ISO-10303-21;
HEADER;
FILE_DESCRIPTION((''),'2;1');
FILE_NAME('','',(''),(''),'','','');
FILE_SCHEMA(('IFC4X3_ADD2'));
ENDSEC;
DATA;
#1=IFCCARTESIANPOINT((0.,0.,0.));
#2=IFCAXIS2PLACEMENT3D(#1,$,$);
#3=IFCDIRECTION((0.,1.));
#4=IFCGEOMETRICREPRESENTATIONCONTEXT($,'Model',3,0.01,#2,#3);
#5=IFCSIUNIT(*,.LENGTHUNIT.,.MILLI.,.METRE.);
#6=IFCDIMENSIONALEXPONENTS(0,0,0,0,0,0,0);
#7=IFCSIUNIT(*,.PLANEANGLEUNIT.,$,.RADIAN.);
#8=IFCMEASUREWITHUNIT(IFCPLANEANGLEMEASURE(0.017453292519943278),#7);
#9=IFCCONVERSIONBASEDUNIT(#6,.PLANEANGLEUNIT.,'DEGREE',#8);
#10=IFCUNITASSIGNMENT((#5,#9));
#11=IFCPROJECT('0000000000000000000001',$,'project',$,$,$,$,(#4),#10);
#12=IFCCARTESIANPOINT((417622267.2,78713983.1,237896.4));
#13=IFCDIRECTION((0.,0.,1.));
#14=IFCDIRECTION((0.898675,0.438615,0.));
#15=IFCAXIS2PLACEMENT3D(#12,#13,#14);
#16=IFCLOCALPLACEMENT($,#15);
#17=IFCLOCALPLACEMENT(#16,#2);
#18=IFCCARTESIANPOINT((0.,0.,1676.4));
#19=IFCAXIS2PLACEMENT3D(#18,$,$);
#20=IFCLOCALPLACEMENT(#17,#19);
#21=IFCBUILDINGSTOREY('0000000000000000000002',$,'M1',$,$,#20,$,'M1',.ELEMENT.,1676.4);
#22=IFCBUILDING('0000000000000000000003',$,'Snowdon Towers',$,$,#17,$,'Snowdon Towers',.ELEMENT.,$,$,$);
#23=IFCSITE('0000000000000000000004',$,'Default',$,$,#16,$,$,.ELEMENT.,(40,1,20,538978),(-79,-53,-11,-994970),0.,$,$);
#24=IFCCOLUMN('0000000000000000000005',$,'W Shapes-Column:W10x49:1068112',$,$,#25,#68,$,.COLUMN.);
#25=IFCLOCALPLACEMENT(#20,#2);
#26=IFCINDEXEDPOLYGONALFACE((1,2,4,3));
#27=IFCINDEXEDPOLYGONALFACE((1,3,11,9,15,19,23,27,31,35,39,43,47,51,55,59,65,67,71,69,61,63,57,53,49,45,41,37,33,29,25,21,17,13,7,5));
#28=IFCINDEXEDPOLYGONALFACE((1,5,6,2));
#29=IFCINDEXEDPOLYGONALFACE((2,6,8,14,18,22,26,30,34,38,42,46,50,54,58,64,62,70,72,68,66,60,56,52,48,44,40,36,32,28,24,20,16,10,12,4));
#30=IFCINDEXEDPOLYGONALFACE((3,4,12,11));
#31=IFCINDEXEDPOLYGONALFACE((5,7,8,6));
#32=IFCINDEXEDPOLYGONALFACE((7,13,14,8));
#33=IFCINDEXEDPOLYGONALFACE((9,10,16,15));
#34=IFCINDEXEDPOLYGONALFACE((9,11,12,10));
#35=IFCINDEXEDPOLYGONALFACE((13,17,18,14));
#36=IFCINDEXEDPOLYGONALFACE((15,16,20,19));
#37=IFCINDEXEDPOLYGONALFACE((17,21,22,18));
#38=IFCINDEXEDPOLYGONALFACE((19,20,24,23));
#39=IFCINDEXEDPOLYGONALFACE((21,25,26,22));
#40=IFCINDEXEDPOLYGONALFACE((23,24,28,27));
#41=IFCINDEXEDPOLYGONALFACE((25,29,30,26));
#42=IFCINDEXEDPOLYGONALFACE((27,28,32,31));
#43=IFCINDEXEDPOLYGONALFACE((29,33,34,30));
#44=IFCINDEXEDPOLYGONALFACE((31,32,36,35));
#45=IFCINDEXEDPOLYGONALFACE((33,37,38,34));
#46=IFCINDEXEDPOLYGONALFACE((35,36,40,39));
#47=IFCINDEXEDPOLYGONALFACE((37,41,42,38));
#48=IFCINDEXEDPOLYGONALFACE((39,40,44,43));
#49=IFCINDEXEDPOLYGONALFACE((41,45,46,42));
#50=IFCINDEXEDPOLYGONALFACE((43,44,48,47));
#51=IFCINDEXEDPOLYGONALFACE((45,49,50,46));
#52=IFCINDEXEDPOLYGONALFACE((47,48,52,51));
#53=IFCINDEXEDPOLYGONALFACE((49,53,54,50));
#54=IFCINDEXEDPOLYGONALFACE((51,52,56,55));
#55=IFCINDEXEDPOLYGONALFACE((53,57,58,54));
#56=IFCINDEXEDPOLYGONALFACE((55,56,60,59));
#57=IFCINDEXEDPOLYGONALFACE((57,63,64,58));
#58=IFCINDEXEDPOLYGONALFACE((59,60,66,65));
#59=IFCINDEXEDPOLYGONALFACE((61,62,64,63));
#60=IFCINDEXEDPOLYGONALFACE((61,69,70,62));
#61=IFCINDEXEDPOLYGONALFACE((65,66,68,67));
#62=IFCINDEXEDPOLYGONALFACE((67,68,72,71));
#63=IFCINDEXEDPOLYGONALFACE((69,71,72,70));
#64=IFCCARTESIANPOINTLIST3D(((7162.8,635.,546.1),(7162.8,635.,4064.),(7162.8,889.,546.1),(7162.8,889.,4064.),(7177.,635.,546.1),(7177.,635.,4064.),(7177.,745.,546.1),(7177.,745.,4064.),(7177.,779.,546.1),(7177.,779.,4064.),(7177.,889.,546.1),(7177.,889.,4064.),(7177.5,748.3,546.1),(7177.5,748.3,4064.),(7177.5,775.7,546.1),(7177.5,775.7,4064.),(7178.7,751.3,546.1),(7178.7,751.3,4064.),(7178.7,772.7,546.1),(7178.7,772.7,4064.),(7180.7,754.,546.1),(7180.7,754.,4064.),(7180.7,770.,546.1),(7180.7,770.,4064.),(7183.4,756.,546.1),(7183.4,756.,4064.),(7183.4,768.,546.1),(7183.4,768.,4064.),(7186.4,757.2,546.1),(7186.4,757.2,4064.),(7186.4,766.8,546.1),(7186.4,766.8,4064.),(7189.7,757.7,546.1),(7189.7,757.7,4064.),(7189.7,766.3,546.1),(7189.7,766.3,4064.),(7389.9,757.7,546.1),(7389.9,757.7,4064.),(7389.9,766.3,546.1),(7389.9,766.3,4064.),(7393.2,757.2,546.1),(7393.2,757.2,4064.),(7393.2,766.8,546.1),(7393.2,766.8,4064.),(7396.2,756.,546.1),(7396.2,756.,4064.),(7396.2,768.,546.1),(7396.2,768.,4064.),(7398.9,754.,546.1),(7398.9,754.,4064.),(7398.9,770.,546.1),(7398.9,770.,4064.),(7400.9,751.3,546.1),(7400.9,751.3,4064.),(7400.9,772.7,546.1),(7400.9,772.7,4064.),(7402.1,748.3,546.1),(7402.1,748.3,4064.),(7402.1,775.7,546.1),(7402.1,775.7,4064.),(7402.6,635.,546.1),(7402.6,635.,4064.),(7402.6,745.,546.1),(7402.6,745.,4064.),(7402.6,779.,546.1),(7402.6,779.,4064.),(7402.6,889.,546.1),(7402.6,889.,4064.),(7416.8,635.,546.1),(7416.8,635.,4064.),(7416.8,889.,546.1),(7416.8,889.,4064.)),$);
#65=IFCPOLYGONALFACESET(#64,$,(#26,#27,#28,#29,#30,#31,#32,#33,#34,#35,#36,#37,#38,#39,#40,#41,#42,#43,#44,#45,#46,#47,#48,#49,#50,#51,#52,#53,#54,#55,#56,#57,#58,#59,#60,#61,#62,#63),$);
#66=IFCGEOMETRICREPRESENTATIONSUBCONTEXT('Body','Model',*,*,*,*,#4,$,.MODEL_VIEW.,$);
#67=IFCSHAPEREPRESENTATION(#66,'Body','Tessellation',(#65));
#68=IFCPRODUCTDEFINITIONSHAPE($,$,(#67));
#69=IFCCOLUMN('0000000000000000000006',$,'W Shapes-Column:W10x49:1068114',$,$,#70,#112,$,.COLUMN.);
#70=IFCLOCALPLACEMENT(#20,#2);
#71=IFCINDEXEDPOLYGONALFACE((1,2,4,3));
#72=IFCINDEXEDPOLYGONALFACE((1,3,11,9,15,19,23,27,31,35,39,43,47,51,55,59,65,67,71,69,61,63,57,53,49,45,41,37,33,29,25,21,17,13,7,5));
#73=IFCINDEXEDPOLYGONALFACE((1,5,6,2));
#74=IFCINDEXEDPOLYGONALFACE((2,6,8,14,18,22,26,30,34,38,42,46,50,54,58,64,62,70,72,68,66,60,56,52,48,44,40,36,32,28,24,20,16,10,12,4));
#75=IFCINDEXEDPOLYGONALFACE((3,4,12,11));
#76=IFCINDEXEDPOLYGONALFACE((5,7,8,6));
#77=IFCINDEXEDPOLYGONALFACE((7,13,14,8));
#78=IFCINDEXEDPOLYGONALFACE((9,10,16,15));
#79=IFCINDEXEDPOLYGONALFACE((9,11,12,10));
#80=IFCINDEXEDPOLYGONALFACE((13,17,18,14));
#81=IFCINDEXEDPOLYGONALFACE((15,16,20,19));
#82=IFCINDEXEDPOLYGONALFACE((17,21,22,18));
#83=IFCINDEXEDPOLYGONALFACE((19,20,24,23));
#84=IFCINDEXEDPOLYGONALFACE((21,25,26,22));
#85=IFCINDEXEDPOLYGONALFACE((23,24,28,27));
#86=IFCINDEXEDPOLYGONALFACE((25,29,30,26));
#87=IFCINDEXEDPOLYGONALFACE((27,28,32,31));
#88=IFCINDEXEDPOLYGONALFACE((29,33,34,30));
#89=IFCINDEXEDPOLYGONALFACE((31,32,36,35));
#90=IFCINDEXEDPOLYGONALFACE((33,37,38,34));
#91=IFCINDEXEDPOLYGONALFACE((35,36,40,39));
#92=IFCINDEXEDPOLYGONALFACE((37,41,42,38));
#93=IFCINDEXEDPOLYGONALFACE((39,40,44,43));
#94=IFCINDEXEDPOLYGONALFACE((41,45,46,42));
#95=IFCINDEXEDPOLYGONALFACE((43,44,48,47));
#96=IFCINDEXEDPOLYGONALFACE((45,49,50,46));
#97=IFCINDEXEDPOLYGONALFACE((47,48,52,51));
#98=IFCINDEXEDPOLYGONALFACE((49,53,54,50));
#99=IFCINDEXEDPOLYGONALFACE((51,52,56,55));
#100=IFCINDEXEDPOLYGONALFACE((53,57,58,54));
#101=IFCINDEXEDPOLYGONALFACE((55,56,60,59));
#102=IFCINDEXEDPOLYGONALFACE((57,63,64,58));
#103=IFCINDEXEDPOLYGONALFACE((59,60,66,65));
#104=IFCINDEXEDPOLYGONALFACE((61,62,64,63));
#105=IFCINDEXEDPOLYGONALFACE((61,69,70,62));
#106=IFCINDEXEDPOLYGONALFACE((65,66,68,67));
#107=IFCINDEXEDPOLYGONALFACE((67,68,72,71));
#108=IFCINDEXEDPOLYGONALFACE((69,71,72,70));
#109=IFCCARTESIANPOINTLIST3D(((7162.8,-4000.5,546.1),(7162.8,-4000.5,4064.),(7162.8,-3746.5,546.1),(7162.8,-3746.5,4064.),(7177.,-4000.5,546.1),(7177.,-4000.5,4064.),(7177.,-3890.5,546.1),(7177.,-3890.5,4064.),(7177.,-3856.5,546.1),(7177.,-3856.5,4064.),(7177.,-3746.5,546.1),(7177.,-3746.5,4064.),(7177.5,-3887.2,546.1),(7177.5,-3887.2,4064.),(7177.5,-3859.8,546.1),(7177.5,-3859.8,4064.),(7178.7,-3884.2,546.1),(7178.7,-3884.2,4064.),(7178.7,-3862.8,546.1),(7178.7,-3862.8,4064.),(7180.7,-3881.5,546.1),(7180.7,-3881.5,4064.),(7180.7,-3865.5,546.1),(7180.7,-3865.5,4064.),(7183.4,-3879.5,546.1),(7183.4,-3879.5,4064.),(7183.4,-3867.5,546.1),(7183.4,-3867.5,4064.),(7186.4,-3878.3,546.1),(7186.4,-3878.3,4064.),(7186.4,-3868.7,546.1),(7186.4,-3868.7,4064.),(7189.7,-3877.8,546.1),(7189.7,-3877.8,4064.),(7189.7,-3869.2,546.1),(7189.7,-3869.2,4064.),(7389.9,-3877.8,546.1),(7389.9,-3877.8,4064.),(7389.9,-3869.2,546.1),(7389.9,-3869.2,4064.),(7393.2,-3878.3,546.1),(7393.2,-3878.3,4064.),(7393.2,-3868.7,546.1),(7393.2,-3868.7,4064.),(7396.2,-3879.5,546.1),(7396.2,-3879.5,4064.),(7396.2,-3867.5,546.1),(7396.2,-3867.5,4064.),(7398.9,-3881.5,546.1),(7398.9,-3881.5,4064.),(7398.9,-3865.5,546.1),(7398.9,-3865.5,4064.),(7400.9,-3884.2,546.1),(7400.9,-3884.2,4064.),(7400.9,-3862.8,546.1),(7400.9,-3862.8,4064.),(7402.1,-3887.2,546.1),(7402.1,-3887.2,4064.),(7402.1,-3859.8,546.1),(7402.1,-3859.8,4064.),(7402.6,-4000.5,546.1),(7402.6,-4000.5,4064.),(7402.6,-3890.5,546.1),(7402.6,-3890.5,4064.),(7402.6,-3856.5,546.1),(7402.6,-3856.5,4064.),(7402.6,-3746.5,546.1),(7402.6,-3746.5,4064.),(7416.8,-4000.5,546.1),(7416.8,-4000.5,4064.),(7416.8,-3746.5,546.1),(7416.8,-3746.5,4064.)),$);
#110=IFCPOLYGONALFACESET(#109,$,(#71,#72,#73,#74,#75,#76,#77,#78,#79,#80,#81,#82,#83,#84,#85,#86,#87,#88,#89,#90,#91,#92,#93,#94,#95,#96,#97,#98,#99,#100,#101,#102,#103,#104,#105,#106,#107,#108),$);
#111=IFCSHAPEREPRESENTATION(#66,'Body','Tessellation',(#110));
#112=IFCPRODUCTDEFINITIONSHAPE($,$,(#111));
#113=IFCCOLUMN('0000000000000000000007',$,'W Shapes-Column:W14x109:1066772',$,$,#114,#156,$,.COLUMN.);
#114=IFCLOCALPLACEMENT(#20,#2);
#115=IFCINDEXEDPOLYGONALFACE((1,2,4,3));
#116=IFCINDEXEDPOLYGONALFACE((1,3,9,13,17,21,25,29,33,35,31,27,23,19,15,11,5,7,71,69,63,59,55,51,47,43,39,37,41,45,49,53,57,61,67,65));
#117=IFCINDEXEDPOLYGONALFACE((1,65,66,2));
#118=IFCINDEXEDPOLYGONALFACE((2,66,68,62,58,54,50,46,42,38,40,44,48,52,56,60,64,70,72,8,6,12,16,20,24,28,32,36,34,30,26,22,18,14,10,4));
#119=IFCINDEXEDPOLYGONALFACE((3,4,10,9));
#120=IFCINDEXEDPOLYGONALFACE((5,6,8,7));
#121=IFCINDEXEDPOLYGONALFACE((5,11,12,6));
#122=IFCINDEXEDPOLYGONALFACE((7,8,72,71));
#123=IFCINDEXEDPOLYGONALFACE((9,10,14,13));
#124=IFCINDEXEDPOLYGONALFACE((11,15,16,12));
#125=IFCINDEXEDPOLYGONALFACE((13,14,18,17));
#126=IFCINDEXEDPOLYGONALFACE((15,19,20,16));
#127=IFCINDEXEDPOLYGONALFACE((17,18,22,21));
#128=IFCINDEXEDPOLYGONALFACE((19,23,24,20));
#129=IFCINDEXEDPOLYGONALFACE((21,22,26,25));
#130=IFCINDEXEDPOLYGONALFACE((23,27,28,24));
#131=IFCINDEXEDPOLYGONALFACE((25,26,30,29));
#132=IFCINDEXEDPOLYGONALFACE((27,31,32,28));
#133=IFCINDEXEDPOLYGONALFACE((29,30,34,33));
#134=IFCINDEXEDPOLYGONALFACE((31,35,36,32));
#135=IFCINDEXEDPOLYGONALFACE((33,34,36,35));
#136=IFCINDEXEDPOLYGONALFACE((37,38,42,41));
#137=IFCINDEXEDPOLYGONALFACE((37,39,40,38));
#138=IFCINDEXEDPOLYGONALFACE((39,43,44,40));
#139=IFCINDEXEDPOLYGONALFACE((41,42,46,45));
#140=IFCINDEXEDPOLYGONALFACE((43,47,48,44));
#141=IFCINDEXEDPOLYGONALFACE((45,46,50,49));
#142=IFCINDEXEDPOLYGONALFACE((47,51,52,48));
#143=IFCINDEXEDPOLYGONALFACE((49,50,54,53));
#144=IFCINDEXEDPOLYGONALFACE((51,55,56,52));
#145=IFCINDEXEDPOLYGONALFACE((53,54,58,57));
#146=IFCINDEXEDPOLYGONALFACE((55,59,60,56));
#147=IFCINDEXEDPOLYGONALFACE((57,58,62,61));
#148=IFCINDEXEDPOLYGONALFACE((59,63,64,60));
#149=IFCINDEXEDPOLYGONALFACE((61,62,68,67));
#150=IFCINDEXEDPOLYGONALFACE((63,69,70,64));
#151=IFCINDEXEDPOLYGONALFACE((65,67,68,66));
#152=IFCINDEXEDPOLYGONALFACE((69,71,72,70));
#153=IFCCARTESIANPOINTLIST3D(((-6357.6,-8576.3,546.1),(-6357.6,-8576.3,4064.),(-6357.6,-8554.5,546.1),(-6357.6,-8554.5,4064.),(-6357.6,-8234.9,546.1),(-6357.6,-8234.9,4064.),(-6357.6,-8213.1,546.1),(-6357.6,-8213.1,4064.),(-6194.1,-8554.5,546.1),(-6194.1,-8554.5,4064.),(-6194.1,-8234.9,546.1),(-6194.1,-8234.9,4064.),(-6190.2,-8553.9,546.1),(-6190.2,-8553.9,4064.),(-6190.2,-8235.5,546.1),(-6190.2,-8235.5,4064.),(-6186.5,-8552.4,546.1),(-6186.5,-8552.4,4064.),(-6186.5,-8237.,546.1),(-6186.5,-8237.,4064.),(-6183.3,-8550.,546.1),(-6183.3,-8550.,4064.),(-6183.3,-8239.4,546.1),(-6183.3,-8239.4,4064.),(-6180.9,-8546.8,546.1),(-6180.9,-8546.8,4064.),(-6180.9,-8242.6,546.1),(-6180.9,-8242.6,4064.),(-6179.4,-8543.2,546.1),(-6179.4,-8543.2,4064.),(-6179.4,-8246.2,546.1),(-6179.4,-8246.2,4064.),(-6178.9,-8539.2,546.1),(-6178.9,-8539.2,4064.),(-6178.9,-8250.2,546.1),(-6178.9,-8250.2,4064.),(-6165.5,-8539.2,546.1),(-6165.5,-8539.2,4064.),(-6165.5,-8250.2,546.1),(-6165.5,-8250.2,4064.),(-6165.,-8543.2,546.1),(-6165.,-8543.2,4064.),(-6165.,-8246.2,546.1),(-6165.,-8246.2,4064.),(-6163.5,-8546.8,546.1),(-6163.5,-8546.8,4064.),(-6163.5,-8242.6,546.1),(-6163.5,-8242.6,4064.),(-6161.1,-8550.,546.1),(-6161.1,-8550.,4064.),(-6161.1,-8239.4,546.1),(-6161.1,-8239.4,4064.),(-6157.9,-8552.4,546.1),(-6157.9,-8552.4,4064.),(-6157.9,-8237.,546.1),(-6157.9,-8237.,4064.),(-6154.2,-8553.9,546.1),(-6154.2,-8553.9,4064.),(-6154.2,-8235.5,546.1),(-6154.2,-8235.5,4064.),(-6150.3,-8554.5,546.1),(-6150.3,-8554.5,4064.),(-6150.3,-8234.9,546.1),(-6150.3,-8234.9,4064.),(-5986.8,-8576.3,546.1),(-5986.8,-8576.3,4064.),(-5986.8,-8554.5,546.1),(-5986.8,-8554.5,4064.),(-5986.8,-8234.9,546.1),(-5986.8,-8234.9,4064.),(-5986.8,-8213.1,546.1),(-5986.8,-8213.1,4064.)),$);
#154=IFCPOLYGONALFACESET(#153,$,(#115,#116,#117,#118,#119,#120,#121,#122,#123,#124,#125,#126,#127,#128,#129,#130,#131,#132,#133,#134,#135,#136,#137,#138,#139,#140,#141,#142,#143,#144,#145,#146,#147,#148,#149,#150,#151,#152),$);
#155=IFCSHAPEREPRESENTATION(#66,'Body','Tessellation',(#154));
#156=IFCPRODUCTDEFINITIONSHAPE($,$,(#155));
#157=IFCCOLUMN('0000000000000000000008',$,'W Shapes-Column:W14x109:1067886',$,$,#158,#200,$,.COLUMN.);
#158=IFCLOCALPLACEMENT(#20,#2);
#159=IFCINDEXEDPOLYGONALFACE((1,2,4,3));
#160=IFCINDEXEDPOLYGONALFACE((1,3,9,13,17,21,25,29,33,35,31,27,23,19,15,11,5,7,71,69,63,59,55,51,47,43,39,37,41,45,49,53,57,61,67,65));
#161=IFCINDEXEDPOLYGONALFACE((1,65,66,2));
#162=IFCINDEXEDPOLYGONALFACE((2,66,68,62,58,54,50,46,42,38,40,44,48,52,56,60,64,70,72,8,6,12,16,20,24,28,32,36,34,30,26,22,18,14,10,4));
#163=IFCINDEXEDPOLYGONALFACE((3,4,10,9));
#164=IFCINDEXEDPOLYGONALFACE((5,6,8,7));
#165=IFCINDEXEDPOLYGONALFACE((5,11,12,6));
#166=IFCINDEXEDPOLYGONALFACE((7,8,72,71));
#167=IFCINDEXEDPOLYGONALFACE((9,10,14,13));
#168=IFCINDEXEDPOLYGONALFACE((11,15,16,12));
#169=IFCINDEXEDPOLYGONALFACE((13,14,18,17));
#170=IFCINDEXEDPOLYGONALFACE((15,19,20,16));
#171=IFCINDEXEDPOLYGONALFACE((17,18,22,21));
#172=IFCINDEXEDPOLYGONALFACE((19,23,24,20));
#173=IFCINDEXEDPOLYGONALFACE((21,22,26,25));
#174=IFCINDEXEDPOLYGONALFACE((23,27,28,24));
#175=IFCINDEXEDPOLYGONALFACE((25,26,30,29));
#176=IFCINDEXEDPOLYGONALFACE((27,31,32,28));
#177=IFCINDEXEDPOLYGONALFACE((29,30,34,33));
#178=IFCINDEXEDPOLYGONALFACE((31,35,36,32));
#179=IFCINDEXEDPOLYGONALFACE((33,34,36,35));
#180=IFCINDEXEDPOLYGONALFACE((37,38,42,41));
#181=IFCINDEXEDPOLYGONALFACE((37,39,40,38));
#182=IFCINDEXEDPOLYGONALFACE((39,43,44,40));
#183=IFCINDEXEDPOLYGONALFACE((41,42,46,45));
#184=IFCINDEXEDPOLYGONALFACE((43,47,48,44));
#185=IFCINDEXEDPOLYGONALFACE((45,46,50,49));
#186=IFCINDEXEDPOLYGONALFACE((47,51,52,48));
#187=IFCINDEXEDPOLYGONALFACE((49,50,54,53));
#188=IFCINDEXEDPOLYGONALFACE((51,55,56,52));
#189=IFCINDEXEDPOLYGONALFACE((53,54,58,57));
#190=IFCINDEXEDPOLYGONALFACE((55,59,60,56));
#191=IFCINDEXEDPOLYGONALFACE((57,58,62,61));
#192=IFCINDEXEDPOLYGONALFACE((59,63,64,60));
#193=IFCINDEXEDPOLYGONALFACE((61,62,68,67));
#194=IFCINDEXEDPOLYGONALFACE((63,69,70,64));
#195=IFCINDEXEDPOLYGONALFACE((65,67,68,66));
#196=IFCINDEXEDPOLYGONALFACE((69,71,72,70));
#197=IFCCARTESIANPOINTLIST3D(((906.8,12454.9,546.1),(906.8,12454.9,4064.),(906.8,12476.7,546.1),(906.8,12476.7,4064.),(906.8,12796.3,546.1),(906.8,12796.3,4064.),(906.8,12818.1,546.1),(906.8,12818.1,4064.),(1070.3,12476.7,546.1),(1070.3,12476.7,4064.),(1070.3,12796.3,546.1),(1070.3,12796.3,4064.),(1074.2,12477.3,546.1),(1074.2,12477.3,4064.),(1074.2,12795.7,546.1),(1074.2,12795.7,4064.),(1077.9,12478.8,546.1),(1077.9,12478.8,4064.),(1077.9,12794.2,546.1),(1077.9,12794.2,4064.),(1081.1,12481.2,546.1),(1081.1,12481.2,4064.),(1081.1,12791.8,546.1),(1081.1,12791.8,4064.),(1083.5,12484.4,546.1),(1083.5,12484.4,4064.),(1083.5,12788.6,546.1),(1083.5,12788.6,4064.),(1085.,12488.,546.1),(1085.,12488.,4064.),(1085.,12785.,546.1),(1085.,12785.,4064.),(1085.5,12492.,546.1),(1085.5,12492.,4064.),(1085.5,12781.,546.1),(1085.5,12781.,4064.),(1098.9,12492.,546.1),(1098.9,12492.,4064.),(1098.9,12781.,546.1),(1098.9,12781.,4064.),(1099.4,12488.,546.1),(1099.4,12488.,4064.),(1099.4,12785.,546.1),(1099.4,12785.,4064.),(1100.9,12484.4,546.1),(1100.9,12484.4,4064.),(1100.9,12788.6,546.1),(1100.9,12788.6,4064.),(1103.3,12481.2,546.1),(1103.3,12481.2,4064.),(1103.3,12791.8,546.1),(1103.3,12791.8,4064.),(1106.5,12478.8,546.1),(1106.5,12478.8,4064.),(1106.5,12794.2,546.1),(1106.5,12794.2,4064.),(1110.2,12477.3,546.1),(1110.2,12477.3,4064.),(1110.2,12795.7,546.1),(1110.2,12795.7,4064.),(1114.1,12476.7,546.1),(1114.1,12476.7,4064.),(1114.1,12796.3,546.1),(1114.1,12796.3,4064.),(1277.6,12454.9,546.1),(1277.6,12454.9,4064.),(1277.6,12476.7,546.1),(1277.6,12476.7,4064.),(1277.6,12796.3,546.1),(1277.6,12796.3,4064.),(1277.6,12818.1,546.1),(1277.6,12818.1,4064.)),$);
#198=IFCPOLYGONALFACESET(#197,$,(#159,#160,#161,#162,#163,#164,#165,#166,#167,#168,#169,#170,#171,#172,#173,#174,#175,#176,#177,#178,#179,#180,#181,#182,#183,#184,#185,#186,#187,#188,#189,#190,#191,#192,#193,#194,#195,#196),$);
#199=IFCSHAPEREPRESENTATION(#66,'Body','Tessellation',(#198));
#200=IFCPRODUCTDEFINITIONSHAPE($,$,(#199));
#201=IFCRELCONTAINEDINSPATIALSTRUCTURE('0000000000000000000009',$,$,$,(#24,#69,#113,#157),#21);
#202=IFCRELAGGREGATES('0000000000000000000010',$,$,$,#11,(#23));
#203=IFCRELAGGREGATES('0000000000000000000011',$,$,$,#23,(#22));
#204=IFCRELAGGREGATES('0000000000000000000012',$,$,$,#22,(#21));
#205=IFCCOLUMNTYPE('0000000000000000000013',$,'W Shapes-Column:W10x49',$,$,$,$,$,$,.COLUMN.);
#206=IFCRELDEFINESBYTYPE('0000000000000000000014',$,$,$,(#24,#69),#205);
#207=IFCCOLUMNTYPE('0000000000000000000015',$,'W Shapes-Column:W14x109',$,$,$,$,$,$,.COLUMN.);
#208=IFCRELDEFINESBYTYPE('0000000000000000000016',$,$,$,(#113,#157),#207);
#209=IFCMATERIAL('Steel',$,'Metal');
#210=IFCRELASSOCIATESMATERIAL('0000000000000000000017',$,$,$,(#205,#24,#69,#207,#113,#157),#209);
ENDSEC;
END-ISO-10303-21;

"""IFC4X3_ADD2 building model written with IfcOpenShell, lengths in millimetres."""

from ifc_helpers import new_model, entity, si_unit, converted_unit, direction, frame, frame_2d, origin, place, context, subcontext, project, spatial, i_section, extrude, source, transform, mapped, material, material_profile, profile_set, profile_usage, type_object, type_shapes, element, save


model = new_model("IFC4X3_ADD2")

# Units and contexts
model_context = context("Model", 3, precision=0.01, world=origin(), true_north=direction((0.0, 1.0)))
body_context = subcontext(model_context, "Body", "Model", "MODEL_VIEW")
ifc_project = project(units=[si_unit("LENGTHUNIT", "METRE", prefix="MILLI"), converted_unit("PLANEANGLEUNIT", "DEGREE", entity("IfcPlaneAngleMeasure", 0.017453292519943278), si_unit("PLANEANGLEUNIT", "RADIAN"), dimensions=[0, 0, 0, 0, 0, 0, 0])], contexts=[model_context])

# Site, building, storey
site_placement = place(None, frame((417622267.2, 78713983.1, 237896.4), z_axis=(0.0, 0.0, 1.0), x_axis=(0.898675, 0.438615, 0.0)))
site = spatial("IfcSite", under=ifc_project, at=site_placement, Name="Default", CompositionType="ELEMENT", RefLatitude=(40, 1, 20, 538978), RefLongitude=(-79, -53, -11, -994970), RefElevation=0.0)
building_placement = place(site_placement, origin())
building = spatial("IfcBuilding", under=site, at=building_placement, Name="Snowdon Towers", LongName="Snowdon Towers", CompositionType="ELEMENT")
storey_placement = place(building_placement, frame((0.0, 0.0, 1676.4)))
storey = spatial("IfcBuildingStorey", under=building, at=storey_placement, Name="M1", LongName="M1", CompositionType="ELEMENT", Elevation=1676.4)

# Columns
ifc_material_1 = material(Name="Steel", Category="Metal")
ifc_material_profile_1 = material_profile(ifc_material_1, i_section(OverallWidth=254.0, OverallDepth=254.0, WebThickness=8.6, FlangeThickness=14.2, FilletRadius=12.7, at=frame_2d((0.0, 0.0), x_axis=(1.0, 0.0))), Name="W10x49")
ifc_profile_set_1 = profile_set([ifc_material_profile_1], Name="W10x49")
ifc_profile_usage_1 = profile_usage(ifc_profile_set_1)
column_type_1 = type_object("IfcColumnType", Name="W Shapes-Column:W10x49", PredefinedType="COLUMN", material=ifc_profile_set_1)
shared_shape_1 = source(origin(), body_context, "Body", "SweptSolid", [
    extrude(i_section(OverallWidth=254.0, OverallDepth=254.0, WebThickness=8.6, FlangeThickness=14.2, FilletRadius=12.7, at=frame_2d((0.0, 0.0), x_axis=(1.0, 0.0))), frame((0.0, 0.0, 2222.5), z_axis=(0.0, 0.0, 1.0), x_axis=(-1.0, 0.0, 0.0)), (0.0, 0.0, 1.0), 3517.9),
])
type_shapes(column_type_1, [shared_shape_1])
for number, where, z_axis, x_axis, name in (
    (1, (7289.8, 762.0, -1676.4), (0.0, 0.0, 1.0), (0.0, 1.0, 0.0), "W Shapes-Column:W10x49:1068112"),
    (2, (7289.8, -3873.5, -1676.4), (0.0, 0.0, 1.0), (0.0, 1.0, 0.0), "W Shapes-Column:W10x49:1068114"),
):
    element("IfcColumn", number, at=place(storey_placement, frame(where, z_axis=z_axis, x_axis=x_axis)), inside=storey, type_object=column_type_1, material=ifc_profile_usage_1, Name=name, PredefinedType="COLUMN", context=body_context, shape_type="MappedRepresentation", body=[
        mapped(shared_shape_1, transform((0.0, 0.0, 0.0), scale=1.0)),
    ])
ifc_material_profile_2 = material_profile(ifc_material_1, i_section(OverallWidth=370.8, OverallDepth=363.2, WebThickness=13.3, FlangeThickness=21.8, FilletRadius=15.2, at=frame_2d((0.0, 0.0), x_axis=(1.0, 0.0))), Name="W14x109")
ifc_profile_set_2 = profile_set([ifc_material_profile_2], Name="W14x109")
ifc_profile_usage_2 = profile_usage(ifc_profile_set_2)
column_type_2 = type_object("IfcColumnType", Name="W Shapes-Column:W14x109", PredefinedType="COLUMN", material=ifc_profile_set_2)
shared_shape_2 = source(origin(), body_context, "Body", "SweptSolid", [
    extrude(i_section(OverallWidth=370.8, OverallDepth=363.2, WebThickness=13.3, FlangeThickness=21.8, FilletRadius=15.2, at=frame_2d((0.0, 0.0), x_axis=(1.0, 0.0))), frame((0.0, 0.0, 2222.5), z_axis=(0.0, 0.0, 1.0), x_axis=(-1.0, 0.0, 0.0)), (0.0, 0.0, 1.0), 3517.9),
])
type_shapes(column_type_2, [shared_shape_2])
for number, where, z_axis, x_axis, name in (
    (3, (-6172.2, -8394.7, -1676.4), (0.0, 0.0, 1.0), (-1.0, 0.0, 0.0), "W Shapes-Column:W14x109:1066772"),
    (4, (1092.2, 12636.5, -1676.4), (0.0, 0.0, 1.0), (-1.0, 0.0, 0.0), "W Shapes-Column:W14x109:1067886"),
):
    element("IfcColumn", number, at=place(storey_placement, frame(where, z_axis=z_axis, x_axis=x_axis)), inside=storey, type_object=column_type_2, material=ifc_profile_usage_2, Name=name, PredefinedType="COLUMN", context=body_context, shape_type="MappedRepresentation", body=[
        mapped(shared_shape_2, transform((0.0, 0.0, 0.0), scale=1.0)),
    ])

save(model, "model.ifc")
